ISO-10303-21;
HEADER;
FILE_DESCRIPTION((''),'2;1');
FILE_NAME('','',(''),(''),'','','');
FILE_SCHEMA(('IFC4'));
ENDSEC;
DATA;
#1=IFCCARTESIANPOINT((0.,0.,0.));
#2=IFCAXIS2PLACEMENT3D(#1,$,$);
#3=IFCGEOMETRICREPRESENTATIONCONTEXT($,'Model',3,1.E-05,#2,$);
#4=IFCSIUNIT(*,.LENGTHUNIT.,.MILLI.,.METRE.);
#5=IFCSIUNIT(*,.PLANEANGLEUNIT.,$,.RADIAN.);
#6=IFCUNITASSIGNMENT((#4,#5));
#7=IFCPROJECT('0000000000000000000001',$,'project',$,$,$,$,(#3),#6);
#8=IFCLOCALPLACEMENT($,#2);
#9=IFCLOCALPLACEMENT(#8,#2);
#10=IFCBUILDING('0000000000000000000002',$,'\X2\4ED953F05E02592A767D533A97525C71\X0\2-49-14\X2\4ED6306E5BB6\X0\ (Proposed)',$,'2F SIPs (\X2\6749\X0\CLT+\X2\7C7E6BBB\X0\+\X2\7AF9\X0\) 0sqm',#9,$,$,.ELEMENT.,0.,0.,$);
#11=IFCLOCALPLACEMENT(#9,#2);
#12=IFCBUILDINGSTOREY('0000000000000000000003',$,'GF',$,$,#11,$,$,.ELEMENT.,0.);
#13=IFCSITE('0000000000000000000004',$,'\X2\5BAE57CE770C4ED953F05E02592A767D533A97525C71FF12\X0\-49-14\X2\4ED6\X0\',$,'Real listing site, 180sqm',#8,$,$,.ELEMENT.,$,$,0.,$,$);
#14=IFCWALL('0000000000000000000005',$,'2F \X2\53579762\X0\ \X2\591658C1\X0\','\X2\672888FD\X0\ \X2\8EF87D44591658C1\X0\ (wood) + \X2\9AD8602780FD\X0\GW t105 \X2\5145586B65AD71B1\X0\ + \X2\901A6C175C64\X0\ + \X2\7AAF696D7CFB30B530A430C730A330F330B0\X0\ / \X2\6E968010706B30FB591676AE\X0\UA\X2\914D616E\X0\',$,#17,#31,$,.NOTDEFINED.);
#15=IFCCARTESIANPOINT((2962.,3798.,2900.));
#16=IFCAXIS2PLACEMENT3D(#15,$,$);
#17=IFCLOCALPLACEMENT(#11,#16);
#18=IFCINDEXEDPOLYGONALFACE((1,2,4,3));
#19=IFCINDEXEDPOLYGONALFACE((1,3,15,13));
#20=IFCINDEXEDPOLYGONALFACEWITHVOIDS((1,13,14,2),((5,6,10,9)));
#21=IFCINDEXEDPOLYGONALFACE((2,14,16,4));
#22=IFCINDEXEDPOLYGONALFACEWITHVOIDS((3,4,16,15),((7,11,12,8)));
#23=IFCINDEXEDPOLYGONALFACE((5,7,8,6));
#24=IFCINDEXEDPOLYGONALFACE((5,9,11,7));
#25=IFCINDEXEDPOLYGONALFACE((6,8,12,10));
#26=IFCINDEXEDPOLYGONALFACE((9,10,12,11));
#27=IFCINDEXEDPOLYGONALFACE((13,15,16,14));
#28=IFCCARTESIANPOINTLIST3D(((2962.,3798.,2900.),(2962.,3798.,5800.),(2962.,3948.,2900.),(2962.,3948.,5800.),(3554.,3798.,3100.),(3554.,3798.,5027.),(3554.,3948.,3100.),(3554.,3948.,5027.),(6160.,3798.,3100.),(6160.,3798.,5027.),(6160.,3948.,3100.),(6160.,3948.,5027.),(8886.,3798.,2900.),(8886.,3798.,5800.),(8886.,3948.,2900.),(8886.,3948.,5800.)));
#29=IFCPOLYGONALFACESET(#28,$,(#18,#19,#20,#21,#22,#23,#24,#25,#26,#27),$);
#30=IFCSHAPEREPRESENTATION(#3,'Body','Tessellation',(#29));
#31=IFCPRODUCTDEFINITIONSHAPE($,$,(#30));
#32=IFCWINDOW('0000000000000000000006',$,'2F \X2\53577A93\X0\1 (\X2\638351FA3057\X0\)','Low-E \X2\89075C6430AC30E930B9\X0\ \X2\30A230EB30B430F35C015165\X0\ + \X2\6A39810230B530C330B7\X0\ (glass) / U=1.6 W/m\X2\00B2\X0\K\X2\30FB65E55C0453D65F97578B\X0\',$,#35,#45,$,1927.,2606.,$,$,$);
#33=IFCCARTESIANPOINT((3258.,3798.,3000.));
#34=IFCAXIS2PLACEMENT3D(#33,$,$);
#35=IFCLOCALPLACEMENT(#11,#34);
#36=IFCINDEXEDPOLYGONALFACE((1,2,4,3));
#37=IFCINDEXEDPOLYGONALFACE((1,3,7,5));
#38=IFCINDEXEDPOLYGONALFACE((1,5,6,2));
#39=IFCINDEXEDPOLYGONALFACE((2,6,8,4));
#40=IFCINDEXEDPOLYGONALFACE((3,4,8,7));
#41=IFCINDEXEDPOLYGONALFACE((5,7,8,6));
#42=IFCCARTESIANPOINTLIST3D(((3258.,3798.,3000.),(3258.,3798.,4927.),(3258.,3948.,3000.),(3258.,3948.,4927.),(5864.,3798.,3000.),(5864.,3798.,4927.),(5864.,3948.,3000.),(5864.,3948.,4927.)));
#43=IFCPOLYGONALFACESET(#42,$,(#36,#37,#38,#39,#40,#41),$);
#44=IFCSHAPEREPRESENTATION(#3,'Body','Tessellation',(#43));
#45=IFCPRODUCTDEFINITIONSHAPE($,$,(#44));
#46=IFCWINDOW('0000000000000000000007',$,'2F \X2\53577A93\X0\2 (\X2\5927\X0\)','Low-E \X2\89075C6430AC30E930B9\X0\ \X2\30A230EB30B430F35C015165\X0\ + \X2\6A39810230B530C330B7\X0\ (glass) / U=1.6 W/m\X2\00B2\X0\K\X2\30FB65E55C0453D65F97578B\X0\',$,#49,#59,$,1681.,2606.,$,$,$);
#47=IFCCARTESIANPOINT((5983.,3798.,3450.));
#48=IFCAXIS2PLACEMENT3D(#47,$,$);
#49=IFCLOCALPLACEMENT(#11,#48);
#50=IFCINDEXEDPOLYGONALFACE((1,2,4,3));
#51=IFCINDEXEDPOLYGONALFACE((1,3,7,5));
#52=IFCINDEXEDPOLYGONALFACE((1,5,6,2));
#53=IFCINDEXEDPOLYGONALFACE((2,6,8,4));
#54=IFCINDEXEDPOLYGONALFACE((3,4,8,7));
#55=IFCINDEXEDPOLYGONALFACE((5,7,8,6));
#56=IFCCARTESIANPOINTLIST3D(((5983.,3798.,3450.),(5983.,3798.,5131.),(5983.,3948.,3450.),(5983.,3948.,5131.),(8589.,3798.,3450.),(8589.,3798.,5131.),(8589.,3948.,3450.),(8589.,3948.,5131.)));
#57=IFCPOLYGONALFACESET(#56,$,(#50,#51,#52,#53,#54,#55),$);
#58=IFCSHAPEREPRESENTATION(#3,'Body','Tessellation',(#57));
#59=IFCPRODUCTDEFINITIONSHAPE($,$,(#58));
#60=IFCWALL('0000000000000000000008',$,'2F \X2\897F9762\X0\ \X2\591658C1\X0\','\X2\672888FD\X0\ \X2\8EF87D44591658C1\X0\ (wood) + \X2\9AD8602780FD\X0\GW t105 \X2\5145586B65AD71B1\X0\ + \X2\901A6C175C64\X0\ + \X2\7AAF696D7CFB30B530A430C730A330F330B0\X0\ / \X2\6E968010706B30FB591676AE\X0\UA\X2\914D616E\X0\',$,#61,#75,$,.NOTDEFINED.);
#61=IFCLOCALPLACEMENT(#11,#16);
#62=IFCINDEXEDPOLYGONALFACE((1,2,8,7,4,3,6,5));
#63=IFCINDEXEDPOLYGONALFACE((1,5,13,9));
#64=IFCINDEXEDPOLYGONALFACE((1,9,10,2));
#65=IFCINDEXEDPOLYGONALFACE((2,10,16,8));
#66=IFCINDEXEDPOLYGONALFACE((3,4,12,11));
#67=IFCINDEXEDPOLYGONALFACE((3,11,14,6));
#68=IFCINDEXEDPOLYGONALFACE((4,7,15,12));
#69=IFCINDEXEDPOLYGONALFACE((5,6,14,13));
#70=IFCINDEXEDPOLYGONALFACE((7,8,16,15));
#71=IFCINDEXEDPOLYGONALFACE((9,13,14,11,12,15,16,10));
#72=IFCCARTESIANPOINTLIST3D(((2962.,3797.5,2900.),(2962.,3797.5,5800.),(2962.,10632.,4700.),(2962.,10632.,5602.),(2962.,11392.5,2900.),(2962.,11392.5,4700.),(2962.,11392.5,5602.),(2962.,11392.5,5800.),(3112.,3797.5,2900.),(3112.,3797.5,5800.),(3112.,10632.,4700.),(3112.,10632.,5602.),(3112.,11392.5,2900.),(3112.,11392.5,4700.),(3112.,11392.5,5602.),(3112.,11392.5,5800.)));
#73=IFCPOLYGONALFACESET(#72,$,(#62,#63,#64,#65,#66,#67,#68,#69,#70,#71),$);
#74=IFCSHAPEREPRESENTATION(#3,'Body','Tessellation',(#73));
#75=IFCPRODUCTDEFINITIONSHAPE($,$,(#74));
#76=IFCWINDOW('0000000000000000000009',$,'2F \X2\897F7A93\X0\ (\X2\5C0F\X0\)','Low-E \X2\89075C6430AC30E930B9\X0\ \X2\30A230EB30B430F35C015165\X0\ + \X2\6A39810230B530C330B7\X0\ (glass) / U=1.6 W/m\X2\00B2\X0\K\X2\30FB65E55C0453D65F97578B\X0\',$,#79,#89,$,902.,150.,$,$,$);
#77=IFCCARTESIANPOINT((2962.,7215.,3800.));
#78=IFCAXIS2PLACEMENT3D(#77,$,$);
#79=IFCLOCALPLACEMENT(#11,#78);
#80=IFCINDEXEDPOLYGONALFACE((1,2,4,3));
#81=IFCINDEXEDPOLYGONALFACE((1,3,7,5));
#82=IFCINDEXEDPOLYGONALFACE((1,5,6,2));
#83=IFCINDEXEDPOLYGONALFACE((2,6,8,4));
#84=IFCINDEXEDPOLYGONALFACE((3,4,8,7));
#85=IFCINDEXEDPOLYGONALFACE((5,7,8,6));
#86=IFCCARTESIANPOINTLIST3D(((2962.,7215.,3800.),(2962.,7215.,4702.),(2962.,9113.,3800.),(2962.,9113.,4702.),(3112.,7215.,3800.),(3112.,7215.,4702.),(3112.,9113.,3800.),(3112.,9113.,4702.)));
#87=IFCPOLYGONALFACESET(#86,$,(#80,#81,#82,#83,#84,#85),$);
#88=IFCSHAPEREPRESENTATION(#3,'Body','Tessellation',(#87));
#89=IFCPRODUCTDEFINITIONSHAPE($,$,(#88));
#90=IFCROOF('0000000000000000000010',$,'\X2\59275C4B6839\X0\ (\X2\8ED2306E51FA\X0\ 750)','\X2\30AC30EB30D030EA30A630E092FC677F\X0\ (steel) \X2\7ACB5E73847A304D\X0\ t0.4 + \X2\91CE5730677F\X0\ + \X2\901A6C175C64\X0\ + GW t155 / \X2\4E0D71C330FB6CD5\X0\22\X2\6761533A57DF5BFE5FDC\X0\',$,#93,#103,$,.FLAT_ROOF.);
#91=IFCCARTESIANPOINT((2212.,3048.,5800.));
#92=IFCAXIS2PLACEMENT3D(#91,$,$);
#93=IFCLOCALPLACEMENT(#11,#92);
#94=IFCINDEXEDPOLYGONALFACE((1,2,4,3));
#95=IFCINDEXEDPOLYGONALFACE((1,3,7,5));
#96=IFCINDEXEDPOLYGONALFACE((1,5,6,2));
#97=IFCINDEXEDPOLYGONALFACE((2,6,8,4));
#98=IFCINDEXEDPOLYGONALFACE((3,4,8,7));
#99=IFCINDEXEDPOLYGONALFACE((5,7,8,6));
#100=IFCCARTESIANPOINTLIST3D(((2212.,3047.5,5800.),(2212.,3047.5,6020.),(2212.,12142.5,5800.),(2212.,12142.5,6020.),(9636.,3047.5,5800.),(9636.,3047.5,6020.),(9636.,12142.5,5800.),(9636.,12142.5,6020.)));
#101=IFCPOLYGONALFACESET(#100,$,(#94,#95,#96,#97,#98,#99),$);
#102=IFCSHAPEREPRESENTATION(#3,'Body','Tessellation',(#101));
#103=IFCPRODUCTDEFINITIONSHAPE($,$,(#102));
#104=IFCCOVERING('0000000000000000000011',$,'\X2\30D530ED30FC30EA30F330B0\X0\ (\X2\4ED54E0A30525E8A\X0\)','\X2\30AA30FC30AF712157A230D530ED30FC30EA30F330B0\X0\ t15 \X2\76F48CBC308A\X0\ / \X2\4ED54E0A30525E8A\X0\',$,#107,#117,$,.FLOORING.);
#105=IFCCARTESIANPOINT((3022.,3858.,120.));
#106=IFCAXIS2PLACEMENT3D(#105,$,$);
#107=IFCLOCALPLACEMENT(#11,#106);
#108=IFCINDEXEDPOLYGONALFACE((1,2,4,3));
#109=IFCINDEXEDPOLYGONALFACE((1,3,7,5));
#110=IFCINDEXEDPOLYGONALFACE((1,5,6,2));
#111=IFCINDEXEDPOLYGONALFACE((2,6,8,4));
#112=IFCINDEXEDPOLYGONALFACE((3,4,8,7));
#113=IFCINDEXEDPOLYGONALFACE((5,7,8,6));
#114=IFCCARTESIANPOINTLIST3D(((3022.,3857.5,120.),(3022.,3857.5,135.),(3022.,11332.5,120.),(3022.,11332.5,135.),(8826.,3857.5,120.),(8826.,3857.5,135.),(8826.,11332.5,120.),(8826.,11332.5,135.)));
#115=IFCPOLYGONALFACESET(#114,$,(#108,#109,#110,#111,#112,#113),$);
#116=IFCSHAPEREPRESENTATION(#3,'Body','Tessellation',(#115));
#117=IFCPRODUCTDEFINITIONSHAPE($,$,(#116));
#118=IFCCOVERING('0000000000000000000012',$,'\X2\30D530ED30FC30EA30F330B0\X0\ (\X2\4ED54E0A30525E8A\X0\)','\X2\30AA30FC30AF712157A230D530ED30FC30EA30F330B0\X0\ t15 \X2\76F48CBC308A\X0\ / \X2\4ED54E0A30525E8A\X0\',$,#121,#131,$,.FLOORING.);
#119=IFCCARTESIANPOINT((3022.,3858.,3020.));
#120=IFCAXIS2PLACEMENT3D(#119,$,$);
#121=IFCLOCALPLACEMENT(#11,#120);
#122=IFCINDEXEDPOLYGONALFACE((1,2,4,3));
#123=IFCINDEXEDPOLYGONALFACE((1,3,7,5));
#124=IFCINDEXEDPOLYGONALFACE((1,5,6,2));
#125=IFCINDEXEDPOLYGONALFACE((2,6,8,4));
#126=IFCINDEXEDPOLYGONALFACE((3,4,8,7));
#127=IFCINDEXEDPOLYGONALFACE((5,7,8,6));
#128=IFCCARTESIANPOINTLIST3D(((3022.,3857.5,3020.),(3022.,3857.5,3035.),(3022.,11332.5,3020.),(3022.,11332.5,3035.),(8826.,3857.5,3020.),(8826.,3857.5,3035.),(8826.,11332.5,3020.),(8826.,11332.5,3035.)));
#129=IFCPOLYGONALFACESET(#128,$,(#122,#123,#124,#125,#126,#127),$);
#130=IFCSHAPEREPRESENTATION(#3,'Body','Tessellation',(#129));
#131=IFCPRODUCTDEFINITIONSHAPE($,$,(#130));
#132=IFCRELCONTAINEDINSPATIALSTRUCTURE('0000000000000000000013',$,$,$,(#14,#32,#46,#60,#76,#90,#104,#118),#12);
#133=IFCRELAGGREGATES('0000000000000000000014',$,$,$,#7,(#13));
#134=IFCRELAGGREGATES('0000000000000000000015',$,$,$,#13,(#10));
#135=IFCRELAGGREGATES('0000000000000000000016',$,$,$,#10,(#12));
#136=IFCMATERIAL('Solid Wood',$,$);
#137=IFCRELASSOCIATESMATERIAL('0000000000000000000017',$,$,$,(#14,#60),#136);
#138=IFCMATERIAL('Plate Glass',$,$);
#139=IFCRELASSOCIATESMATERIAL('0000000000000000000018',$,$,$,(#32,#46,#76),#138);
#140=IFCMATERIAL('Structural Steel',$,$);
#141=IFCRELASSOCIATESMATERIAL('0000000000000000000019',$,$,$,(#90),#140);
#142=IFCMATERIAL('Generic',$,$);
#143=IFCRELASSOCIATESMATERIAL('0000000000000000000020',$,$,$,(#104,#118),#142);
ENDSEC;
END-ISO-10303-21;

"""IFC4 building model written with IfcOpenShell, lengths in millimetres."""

from ifc_helpers import new_model, si_unit, frame, frame_2d, origin, place, context, project, spatial, rectangle, extrude, material, element, fill, save


model = new_model("IFC4")

# Units and contexts
model_context = context("Model", 3, precision=1e-05, world=origin())
ifc_project = project(units=[si_unit("LENGTHUNIT", "METRE", prefix="MILLI"), si_unit("PLANEANGLEUNIT", "RADIAN")], contexts=[model_context])

# Site, building, storey
site_placement = place(None, origin())
site = spatial("IfcSite", under=ifc_project, at=site_placement, Name="宮城県仙台市太白区青山２-49-14他", ObjectType="Real listing site, 180sqm", CompositionType="ELEMENT", RefElevation=0.0)
building_placement = place(site_placement, origin())
building = spatial("IfcBuilding", under=site, at=building_placement, Name="仙台市太白区青山2-49-14他の家 (Proposed)", ObjectType="2F SIPs (杉CLT+籾殻+竹) 0sqm", CompositionType="ELEMENT", ElevationOfRefHeight=0.0, ElevationOfTerrain=0.0)
storey_placement = place(building_placement, origin())
storey = spatial("IfcBuildingStorey", under=building, at=storey_placement, Name="GF", CompositionType="ELEMENT", Elevation=0.0)

# Shared definitions
ifc_material_1 = material(Name="Solid Wood")

# Shared definitions
ifc_material_2 = material(Name="Plate Glass")

# Wall, openings, windows
wall_1_placement = place(storey_placement, frame((2962.0, 3798.0, 2900.0)))
wall_1 = element("IfcWall", 1, at=wall_1_placement, inside=storey, material=ifc_material_1, Name="2F 南面 外壁", Description="木製 軸組外壁 (wood) + 高性能GW t105 充填断熱 + 通気層 + 窯業系サイディング / 準耐火・外皮UA配慮", PredefinedType="NOTDEFINED", context=model_context, shape_type="SweptSolid", body=[
    extrude(rectangle(XDim=5924.0, YDim=150.0, at=frame_2d((2962.0, 75.0))), frame((2962.0, 3798.0, 2900.0)), (0.0, 0.0, 1.0), 2900.0),
])
opening_1_placement = place(storey_placement, frame((3258.0, 3798.0, 3000.0)))
opening_1 = element("IfcOpeningElement", 2, at=opening_1_placement, cuts=wall_1, PredefinedType="NOTDEFINED", context=model_context, shape_type="SweptSolid", body=[
    extrude(rectangle(XDim=2606.0, YDim=150.0, at=frame_2d((1303.0, 75.0))), frame((3258.0, 3798.0, 3000.0)), (0.0, 0.0, 1.0), 1927.0),
])
opening_2_placement = place(storey_placement, frame((5983.0, 3798.0, 3450.0)))
opening_2 = element("IfcOpeningElement", 3, at=opening_2_placement, cuts=wall_1, PredefinedType="NOTDEFINED", context=model_context, shape_type="SweptSolid", body=[
    extrude(rectangle(XDim=2606.0, YDim=150.0, at=frame_2d((1303.0, 75.0))), frame((5983.0, 3798.0, 3450.0)), (0.0, 0.0, 1.0), 1681.0),
])
window_1_placement = place(storey_placement, frame((3258.0, 3798.0, 3000.0)))
window_1 = element("IfcWindow", 4, at=window_1_placement, inside=storey, material=ifc_material_2, Name="2F 南窓1 (掃出し)", Description="Low-E 複層ガラス アルゴン封入 + 樹脂サッシ (glass) / U=1.6 W/m²K・日射取得型", OverallHeight=1927.0, OverallWidth=2606.0, context=model_context, shape_type="SweptSolid", body=[
    extrude(rectangle(XDim=2606.0, YDim=150.0, at=frame_2d((1303.0, 75.0))), frame((3258.0, 3798.0, 3000.0)), (0.0, 0.0, 1.0), 1927.0),
])
fill(opening_1, window_1)
window_2_placement = place(storey_placement, frame((5983.0, 3798.0, 3450.0)))
window_2 = element("IfcWindow", 5, at=window_2_placement, inside=storey, material=ifc_material_2, Name="2F 南窓2 (大)", Description="Low-E 複層ガラス アルゴン封入 + 樹脂サッシ (glass) / U=1.6 W/m²K・日射取得型", OverallHeight=1681.0, OverallWidth=2606.0, context=model_context, shape_type="SweptSolid", body=[
    extrude(rectangle(XDim=2606.0, YDim=150.0, at=frame_2d((1303.0, 75.0))), frame((5983.0, 3798.0, 3450.0)), (0.0, 0.0, 1.0), 1681.0),
])
fill(opening_2, window_2)

# Wall, opening, window
wall_2_placement = place(storey_placement, frame((2962.0, 3798.0, 2900.0)))
wall_2 = element("IfcWall", 6, at=wall_2_placement, inside=storey, material=ifc_material_1, Name="2F 西面 外壁", Description="木製 軸組外壁 (wood) + 高性能GW t105 充填断熱 + 通気層 + 窯業系サイディング / 準耐火・外皮UA配慮", PredefinedType="NOTDEFINED", context=model_context, shape_type="SweptSolid", body=[
    extrude(rectangle(XDim=150.0, YDim=7595.0, at=frame_2d((75.0, 3797.0))), frame((2962.0, 3798.0, 2900.0)), (0.0, 0.0, 1.0), 2900.0),
])
opening_3_placement = place(storey_placement, frame((2962.0, 7215.0, 3800.0)))
opening_3 = element("IfcOpeningElement", 7, at=opening_3_placement, cuts=wall_2, PredefinedType="NOTDEFINED", context=model_context, shape_type="SweptSolid", body=[
    extrude(rectangle(XDim=150.0, YDim=1898.0, at=frame_2d((75.0, 949.0))), frame((2962.0, 7215.0, 3800.0)), (0.0, 0.0, 1.0), 902.0),
])
window_3_placement = place(storey_placement, frame((2962.0, 7215.0, 3800.0)))
window_3 = element("IfcWindow", 8, at=window_3_placement, inside=storey, material=ifc_material_2, Name="2F 西窓 (小)", Description="Low-E 複層ガラス アルゴン封入 + 樹脂サッシ (glass) / U=1.6 W/m²K・日射取得型", OverallHeight=902.0, OverallWidth=150.0, context=model_context, shape_type="SweptSolid", body=[
    extrude(rectangle(XDim=150.0, YDim=1898.0, at=frame_2d((75.0, 949.0))), frame((2962.0, 7215.0, 3800.0)), (0.0, 0.0, 1.0), 902.0),
])
fill(opening_3, window_3)

# Roof
ifc_material_3 = material(Name="Structural Steel")
roof_placement = place(storey_placement, frame((2212.0, 3048.0, 5800.0)))
element("IfcRoof", 9, at=roof_placement, inside=storey, material=ifc_material_3, Name="大屋根 (軒の出 750)", Description="ガルバリウム鋼板 (steel) 立平葺き t0.4 + 野地板 + 通気層 + GW t155 / 不燃・法22条区域対応", PredefinedType="FLAT_ROOF", context=model_context, shape_type="SweptSolid", body=[
    extrude(rectangle(XDim=7424.0, YDim=9095.0, at=frame_2d((3712.0, 4547.0))), frame((2212.0, 3048.0, 5800.0)), (0.0, 0.0, 1.0), 220.0),
])

# Coverings
ifc_material_4 = material(Name="Generic")
covering_1_placement = place(storey_placement, frame((3022.0, 3858.0, 120.0)))
element("IfcCovering", 10, at=covering_1_placement, inside=storey, material=ifc_material_4, Name="フローリング (仕上げ床)", Description="オーク無垢フローリング t15 直貼り / 仕上げ床", PredefinedType="FLOORING", context=model_context, shape_type="SweptSolid", body=[
    extrude(rectangle(XDim=5804.0, YDim=7475.0, at=frame_2d((2902.0, 3737.0))), frame((3022.0, 3858.0, 120.0)), (0.0, 0.0, 1.0), 15.0),
])
covering_2_placement = place(storey_placement, frame((3022.0, 3858.0, 3020.0)))
element("IfcCovering", 11, at=covering_2_placement, inside=storey, material=ifc_material_4, Name="フローリング (仕上げ床)", Description="オーク無垢フローリング t15 直貼り / 仕上げ床", PredefinedType="FLOORING", context=model_context, shape_type="SweptSolid", body=[
    extrude(rectangle(XDim=5804.0, YDim=7475.0, at=frame_2d((2902.0, 3737.0))), frame((3022.0, 3858.0, 3020.0)), (0.0, 0.0, 1.0), 15.0),
])

save(model, "model.ifc")
